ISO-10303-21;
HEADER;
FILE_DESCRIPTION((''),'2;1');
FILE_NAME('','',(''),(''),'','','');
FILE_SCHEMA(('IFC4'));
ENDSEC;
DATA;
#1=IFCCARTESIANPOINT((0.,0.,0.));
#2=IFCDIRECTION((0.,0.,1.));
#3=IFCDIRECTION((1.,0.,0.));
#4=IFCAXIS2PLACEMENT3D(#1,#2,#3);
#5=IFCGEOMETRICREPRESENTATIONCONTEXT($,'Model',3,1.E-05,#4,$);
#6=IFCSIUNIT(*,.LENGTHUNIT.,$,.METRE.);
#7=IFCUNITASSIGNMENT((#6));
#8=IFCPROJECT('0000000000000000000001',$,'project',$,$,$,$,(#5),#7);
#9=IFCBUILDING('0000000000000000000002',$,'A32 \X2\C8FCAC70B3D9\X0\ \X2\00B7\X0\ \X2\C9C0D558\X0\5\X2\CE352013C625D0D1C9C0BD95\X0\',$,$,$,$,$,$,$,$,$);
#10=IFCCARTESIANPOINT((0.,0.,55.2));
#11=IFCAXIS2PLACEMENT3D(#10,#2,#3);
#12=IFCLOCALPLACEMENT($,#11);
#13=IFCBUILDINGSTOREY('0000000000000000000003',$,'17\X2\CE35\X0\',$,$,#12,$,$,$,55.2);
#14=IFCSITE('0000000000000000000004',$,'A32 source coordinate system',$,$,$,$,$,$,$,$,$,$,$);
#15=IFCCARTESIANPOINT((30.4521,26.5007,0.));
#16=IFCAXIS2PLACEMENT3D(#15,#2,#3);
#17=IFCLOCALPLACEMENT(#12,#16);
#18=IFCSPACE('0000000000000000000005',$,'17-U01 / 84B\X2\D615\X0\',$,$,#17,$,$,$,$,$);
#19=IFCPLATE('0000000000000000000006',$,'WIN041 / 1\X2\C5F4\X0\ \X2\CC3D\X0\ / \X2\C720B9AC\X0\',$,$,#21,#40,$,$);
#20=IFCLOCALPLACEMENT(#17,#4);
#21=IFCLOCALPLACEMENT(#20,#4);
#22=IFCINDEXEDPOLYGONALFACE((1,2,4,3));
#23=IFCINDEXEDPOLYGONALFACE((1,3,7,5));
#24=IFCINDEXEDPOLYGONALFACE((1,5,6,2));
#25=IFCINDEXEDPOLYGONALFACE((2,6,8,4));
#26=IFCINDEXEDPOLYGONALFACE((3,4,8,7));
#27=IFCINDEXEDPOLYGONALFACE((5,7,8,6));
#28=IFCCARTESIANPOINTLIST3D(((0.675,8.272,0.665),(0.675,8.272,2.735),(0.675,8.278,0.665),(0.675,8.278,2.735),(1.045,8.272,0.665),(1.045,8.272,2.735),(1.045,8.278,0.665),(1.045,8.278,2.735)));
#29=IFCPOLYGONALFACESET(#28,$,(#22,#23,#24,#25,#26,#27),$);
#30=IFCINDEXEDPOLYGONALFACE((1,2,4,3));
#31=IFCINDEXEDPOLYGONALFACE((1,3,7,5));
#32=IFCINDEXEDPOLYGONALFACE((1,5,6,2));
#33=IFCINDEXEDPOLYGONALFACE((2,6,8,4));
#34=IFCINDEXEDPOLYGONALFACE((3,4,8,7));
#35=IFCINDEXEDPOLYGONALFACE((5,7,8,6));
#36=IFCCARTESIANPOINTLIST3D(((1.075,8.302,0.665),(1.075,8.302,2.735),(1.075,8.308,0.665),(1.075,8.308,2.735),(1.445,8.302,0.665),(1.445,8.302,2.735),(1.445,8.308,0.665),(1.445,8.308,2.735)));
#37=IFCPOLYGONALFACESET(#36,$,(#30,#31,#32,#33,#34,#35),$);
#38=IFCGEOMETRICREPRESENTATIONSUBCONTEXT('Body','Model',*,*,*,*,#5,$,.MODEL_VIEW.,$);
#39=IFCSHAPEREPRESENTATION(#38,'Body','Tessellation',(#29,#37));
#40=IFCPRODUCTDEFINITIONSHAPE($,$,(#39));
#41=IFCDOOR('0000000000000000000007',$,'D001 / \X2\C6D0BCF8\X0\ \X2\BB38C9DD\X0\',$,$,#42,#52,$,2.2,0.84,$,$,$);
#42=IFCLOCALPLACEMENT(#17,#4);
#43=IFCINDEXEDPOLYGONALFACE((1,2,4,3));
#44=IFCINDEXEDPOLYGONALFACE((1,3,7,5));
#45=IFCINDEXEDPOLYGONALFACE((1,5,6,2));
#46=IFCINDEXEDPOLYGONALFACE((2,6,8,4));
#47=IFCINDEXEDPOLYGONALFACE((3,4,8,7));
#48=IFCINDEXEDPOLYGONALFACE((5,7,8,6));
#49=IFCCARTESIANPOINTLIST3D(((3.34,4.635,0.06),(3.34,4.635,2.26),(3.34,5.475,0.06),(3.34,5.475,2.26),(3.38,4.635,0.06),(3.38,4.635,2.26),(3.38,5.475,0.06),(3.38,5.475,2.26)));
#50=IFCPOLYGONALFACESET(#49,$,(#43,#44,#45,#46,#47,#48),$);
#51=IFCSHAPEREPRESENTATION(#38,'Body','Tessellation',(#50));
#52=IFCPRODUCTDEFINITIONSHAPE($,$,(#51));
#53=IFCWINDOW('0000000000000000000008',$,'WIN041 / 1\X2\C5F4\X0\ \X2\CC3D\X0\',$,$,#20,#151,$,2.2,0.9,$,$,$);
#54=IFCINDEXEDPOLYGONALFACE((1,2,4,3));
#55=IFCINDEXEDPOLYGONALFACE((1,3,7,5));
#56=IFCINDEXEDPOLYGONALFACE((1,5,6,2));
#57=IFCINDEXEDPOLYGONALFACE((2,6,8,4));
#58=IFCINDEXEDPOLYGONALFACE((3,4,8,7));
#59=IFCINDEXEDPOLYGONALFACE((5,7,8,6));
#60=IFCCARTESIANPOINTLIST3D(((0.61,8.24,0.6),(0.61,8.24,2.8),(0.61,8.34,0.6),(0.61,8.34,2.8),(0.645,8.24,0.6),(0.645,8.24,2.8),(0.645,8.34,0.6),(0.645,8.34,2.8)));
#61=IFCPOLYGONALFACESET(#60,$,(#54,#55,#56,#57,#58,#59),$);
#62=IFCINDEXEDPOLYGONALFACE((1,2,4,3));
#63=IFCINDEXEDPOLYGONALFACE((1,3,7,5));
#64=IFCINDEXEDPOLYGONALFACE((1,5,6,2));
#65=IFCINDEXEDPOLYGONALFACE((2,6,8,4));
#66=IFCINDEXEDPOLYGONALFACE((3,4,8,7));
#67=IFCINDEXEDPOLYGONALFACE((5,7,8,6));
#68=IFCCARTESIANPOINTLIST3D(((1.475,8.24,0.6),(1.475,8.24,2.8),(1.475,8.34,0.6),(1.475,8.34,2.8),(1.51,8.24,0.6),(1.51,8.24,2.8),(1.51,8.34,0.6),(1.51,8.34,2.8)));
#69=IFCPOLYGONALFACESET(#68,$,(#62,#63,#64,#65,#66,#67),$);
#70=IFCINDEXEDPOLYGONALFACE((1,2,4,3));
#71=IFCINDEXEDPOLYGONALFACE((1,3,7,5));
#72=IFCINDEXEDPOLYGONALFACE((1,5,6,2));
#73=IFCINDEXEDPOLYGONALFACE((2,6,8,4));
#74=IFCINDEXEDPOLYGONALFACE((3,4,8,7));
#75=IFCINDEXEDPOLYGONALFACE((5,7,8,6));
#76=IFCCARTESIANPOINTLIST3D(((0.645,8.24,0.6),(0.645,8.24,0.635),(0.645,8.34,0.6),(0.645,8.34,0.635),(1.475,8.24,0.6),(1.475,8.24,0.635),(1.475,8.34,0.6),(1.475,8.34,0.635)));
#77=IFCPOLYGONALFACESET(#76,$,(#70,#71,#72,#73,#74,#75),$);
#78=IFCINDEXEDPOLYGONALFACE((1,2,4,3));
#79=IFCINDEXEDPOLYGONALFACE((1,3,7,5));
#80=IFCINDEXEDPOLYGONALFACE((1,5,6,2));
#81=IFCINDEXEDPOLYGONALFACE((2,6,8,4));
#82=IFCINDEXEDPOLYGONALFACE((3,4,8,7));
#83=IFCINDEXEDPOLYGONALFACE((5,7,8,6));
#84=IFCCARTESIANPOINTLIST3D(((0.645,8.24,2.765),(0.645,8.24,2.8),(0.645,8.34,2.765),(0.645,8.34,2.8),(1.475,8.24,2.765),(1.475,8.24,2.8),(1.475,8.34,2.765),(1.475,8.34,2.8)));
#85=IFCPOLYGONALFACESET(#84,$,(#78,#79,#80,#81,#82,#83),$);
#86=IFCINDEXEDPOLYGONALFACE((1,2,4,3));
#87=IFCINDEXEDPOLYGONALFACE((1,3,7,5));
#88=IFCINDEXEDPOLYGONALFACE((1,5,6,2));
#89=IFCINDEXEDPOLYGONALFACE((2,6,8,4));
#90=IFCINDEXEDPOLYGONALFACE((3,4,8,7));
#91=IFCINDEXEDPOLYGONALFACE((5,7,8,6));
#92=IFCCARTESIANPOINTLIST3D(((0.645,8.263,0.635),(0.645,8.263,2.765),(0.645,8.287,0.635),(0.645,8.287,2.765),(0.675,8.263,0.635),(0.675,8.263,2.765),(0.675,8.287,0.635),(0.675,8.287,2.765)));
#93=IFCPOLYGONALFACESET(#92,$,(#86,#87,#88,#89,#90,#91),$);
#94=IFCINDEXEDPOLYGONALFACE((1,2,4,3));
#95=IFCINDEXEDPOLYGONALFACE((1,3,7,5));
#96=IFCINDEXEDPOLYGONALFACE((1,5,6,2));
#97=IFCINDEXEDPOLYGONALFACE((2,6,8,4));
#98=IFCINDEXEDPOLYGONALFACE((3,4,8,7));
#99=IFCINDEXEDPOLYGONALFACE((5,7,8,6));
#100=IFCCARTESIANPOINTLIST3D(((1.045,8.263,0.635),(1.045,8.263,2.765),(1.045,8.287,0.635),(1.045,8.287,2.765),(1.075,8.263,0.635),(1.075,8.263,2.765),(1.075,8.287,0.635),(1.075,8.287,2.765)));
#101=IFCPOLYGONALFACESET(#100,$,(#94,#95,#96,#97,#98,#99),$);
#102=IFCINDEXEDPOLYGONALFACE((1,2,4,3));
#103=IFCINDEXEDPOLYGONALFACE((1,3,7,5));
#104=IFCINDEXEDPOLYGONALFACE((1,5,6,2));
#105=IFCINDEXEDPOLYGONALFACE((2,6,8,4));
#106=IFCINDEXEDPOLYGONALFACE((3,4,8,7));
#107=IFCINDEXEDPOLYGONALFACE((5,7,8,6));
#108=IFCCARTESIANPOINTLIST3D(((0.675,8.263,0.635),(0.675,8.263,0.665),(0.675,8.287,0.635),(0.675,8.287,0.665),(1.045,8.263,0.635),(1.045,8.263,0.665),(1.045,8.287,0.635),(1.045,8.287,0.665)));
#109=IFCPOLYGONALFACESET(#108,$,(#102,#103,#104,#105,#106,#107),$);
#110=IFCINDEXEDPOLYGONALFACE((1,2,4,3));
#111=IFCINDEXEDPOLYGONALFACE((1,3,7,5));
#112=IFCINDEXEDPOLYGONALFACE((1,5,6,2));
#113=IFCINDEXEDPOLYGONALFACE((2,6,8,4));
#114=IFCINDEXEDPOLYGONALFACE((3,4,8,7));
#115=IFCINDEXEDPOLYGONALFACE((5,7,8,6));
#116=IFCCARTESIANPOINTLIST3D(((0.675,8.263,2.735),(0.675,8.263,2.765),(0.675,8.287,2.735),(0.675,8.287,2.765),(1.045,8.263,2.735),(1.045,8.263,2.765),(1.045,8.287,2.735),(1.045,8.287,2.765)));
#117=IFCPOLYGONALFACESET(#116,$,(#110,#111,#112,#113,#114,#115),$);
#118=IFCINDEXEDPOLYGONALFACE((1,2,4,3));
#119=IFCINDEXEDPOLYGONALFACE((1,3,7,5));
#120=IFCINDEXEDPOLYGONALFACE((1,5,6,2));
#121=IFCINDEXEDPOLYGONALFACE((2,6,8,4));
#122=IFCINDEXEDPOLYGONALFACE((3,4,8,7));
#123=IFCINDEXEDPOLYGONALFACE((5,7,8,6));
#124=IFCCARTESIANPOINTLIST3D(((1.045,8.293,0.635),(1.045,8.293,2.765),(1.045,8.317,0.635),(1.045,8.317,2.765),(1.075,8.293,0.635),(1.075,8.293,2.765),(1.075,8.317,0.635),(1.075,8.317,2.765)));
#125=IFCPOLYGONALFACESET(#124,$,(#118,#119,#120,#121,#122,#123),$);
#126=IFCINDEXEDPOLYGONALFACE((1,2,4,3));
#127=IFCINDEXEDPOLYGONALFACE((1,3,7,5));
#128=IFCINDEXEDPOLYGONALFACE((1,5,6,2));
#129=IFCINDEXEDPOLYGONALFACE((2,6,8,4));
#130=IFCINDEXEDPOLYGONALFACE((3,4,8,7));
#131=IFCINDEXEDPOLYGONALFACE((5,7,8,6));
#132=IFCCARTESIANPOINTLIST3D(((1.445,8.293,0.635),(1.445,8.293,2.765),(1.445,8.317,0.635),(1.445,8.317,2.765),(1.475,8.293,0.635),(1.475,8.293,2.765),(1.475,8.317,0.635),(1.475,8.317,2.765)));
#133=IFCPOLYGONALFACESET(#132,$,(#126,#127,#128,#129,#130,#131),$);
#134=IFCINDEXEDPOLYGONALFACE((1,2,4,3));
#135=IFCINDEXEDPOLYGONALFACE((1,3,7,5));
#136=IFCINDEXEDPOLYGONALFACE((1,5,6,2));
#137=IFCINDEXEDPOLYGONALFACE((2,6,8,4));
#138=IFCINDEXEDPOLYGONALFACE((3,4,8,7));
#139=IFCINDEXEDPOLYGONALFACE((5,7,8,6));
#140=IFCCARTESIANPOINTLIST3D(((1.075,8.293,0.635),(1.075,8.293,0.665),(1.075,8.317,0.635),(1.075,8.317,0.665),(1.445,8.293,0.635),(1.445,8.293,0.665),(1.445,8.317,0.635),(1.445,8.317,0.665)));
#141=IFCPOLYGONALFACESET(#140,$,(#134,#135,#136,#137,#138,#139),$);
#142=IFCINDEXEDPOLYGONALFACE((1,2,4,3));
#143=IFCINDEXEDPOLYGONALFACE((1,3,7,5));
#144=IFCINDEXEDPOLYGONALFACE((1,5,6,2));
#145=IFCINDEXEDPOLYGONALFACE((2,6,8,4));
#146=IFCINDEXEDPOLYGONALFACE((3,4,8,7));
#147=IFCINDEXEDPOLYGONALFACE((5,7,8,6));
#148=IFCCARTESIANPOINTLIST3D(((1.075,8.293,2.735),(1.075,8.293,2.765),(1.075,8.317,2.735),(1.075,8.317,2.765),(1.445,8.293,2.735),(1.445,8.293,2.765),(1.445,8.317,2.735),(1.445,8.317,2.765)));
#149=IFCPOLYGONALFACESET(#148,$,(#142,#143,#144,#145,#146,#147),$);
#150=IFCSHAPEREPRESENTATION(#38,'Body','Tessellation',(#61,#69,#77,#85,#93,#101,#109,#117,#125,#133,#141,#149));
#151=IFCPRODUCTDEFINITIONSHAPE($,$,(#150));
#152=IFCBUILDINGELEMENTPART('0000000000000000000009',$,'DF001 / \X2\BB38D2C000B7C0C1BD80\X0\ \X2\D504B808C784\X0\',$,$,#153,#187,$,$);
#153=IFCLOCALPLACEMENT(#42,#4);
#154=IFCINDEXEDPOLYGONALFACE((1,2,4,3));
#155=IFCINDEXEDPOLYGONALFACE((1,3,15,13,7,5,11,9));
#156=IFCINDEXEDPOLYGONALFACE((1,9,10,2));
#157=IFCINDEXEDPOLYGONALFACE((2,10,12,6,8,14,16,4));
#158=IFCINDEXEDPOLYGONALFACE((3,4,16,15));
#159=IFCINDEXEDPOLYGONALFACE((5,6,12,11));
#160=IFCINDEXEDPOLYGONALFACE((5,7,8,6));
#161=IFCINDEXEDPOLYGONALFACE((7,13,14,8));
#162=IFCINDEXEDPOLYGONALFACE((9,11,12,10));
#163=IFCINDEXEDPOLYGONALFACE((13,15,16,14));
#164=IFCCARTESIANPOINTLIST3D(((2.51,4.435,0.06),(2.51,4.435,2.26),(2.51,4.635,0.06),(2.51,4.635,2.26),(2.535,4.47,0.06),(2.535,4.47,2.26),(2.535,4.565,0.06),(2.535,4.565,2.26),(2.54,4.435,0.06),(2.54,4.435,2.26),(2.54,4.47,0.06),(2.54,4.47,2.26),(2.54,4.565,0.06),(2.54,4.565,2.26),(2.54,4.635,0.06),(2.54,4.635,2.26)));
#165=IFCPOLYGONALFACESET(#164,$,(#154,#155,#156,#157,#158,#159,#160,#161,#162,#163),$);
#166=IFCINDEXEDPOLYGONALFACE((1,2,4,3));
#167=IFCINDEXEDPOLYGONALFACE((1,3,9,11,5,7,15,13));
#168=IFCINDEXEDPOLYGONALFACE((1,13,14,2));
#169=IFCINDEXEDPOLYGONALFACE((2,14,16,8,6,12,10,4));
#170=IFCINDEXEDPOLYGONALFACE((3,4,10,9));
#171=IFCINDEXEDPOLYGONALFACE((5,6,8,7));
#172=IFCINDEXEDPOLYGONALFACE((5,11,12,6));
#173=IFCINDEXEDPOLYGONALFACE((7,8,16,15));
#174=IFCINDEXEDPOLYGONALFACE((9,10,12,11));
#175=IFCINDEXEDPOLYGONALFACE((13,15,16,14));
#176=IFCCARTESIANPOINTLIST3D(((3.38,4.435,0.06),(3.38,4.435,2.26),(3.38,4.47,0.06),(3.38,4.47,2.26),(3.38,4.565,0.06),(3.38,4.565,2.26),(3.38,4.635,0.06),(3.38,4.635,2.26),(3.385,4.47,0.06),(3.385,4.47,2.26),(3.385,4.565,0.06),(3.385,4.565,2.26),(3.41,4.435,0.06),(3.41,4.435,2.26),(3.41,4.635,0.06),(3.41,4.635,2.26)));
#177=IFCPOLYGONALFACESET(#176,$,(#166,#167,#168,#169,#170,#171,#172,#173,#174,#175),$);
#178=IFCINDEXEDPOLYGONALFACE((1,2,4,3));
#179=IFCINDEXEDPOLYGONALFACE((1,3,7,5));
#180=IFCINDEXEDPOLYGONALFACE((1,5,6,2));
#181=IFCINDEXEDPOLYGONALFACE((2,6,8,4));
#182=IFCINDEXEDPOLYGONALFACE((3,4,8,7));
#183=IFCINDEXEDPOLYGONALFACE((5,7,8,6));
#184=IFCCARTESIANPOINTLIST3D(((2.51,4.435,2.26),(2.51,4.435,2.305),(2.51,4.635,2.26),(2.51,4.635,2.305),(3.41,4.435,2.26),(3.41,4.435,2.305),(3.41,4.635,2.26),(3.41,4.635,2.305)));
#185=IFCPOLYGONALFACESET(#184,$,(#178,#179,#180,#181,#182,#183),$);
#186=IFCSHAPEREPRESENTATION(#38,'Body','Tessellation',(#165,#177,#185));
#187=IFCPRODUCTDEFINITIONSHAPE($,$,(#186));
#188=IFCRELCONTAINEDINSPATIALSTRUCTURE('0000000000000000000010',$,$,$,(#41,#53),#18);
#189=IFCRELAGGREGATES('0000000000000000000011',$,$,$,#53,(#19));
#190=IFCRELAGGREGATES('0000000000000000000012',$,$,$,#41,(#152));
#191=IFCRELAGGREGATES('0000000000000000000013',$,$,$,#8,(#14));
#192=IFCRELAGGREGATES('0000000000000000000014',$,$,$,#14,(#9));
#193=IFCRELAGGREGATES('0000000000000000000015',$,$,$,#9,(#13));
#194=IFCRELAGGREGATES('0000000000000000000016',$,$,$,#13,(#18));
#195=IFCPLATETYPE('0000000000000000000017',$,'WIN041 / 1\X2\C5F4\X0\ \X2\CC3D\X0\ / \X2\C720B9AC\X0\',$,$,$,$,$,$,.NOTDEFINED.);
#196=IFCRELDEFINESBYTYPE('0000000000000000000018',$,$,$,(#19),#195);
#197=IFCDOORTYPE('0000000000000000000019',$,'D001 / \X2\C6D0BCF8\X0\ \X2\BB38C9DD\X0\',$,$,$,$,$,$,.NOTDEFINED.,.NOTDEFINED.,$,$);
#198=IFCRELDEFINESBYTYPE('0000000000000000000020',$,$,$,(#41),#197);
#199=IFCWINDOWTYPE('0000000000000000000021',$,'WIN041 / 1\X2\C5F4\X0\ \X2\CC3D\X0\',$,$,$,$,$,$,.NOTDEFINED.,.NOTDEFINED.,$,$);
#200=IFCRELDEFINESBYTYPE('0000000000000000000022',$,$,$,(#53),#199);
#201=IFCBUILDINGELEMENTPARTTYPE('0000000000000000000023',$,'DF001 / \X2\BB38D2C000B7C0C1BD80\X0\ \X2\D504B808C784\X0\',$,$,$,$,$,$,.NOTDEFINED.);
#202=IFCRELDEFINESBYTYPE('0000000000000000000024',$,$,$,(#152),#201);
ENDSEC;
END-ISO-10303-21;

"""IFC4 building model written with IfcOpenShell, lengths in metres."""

from ifc_helpers import new_model, si_unit, frame, origin, origin_with_axes, place, context, subcontext, project, spatial, polyline, outline, extrude, source, transform, mapped, type_object, type_shapes, element, aggregate, save


model = new_model("IFC4")

# Units and contexts
model_context = context("Model", 3, precision=1e-05, world=origin_with_axes())
body_context = subcontext(model_context, "Body", "Model", "MODEL_VIEW")
ifc_project = project(units=[si_unit("LENGTHUNIT", "METRE")], contexts=[model_context])

# Plate
storey_placement = place(None, frame((0.0, 0.0, 55.2), z_axis=(0.0, 0.0, 1.0), x_axis=(1.0, 0.0, 0.0)))
space_placement = place(storey_placement, frame((30.4521, 26.5007, 0.0), z_axis=(0.0, 0.0, 1.0), x_axis=(1.0, 0.0, 0.0)))
plate_type_1 = type_object("IfcPlateType", Name="WIN041 / 1열 창 / 유리", PredefinedType="NOTDEFINED")
shared_shape_1 = source(origin(), body_context, "Body", "SweptSolid", [
    extrude(outline(polyline([(0.675, 8.272), (0.675, 8.278), (1.045, 8.278), (1.045, 8.272), (0.675, 8.272)])), frame((0.0, 0.0, 0.665)), (0.0, 0.0, 1.0), 2.07),
    extrude(outline(polyline([(1.075, 8.302), (1.075, 8.308), (1.445, 8.308), (1.445, 8.302), (1.075, 8.302)])), frame((0.0, 0.0, 0.665)), (0.0, 0.0, 1.0), 2.07),
])
type_shapes(plate_type_1, [shared_shape_1])
window_1_placement = place(space_placement, origin_with_axes())
plate_1_placement = place(window_1_placement, origin_with_axes())
plate_1 = element("IfcPlate", 1, at=plate_1_placement, type_object=plate_type_1, Name="WIN041 / 1열 창 / 유리", context=body_context, shape_type="MappedRepresentation", body=[
    mapped(shared_shape_1, transform((0.0, 0.0, 0.0), scale=1.0)),
])

# Site, building, storey, space
site = spatial("IfcSite", under=ifc_project, Name="A32 source coordinate system")
building = spatial("IfcBuilding", under=site, Name="A32 주거동 · 지하5층–옥탑지붕")
storey = spatial("IfcBuildingStorey", under=building, at=storey_placement, Name="17층", Elevation=55.2)
space = spatial("IfcSpace", under=storey, at=space_placement, Name="17-U01 / 84B형")

# Door
door_type_1 = type_object("IfcDoorType", Name="D001 / 원본 문짝", OperationType="NOTDEFINED", PredefinedType="NOTDEFINED")
shared_shape_2 = source(origin(), body_context, "Body", "SweptSolid", [
    extrude(outline(polyline([(3.34, 5.475), (3.38, 5.475), (3.38, 4.635), (3.34, 4.635), (3.34, 5.475)])), frame((0.0, 0.0, 0.06)), (0.0, 0.0, 1.0), 2.2),
])
type_shapes(door_type_1, [shared_shape_2])
door_1_placement = place(space_placement, origin_with_axes())
door_1 = element("IfcDoor", 2, at=door_1_placement, inside=space, type_object=door_type_1, Name="D001 / 원본 문짝", OverallHeight=2.2, OverallWidth=0.84, context=body_context, shape_type="MappedRepresentation", body=[
    mapped(shared_shape_2, transform((0.0, 0.0, 0.0), scale=1.0)),
])

# Window
window_type_1 = type_object("IfcWindowType", Name="WIN041 / 1열 창", PartitioningType="NOTDEFINED", PredefinedType="NOTDEFINED")
shared_shape_3 = source(origin(), body_context, "Body", "SweptSolid", [
    extrude(outline(polyline([(0.61, 8.24), (0.61, 8.34), (0.645, 8.34), (0.645, 8.24), (0.61, 8.24)])), frame((0.0, 0.0, 0.6)), (0.0, 0.0, 1.0), 2.2),
    extrude(outline(polyline([(1.475, 8.24), (1.475, 8.34), (1.51, 8.34), (1.51, 8.24), (1.475, 8.24)])), frame((0.0, 0.0, 0.6)), (0.0, 0.0, 1.0), 2.2),
    extrude(outline(polyline([(0.645, 8.24), (0.645, 8.34), (1.475, 8.34), (1.475, 8.24), (0.645, 8.24)])), frame((0.0, 0.0, 0.6)), (0.0, 0.0, 1.0), 0.035),
    extrude(outline(polyline([(0.645, 8.24), (0.645, 8.34), (1.475, 8.34), (1.475, 8.24), (0.645, 8.24)])), frame((0.0, 0.0, 2.765)), (0.0, 0.0, 1.0), 0.035),
    extrude(outline(polyline([(0.645, 8.263), (0.645, 8.287), (0.675, 8.287), (0.675, 8.263), (0.645, 8.263)])), frame((0.0, 0.0, 0.635)), (0.0, 0.0, 1.0), 2.13),
    extrude(outline(polyline([(1.045, 8.263), (1.045, 8.287), (1.075, 8.287), (1.075, 8.263), (1.045, 8.263)])), frame((0.0, 0.0, 0.635)), (0.0, 0.0, 1.0), 2.13),
    extrude(outline(polyline([(0.675, 8.263), (0.675, 8.287), (1.045, 8.287), (1.045, 8.263), (0.675, 8.263)])), frame((0.0, 0.0, 0.635)), (0.0, 0.0, 1.0), 0.03),
    extrude(outline(polyline([(0.675, 8.263), (0.675, 8.287), (1.045, 8.287), (1.045, 8.263), (0.675, 8.263)])), frame((0.0, 0.0, 2.735)), (0.0, 0.0, 1.0), 0.03),
    extrude(outline(polyline([(1.045, 8.293), (1.045, 8.317), (1.075, 8.317), (1.075, 8.293), (1.045, 8.293)])), frame((0.0, 0.0, 0.635)), (0.0, 0.0, 1.0), 2.13),
    extrude(outline(polyline([(1.445, 8.293), (1.445, 8.317), (1.475, 8.317), (1.475, 8.293), (1.445, 8.293)])), frame((0.0, 0.0, 0.635)), (0.0, 0.0, 1.0), 2.13),
    extrude(outline(polyline([(1.075, 8.293), (1.075, 8.317), (1.445, 8.317), (1.445, 8.293), (1.075, 8.293)])), frame((0.0, 0.0, 0.635)), (0.0, 0.0, 1.0), 0.03),
    extrude(outline(polyline([(1.075, 8.293), (1.075, 8.317), (1.445, 8.317), (1.445, 8.293), (1.075, 8.293)])), frame((0.0, 0.0, 2.735)), (0.0, 0.0, 1.0), 0.03),
])
type_shapes(window_type_1, [shared_shape_3])
window_1 = element("IfcWindow", 3, at=window_1_placement, inside=space, type_object=window_type_1, Name="WIN041 / 1열 창", OverallHeight=2.2, OverallWidth=0.9, context=body_context, shape_type="MappedRepresentation", body=[
    mapped(shared_shape_3, transform((0.0, 0.0, 0.0), scale=1.0)),
])
aggregate(window_1, [plate_1])

# Building element part
building_element_part_type_1 = type_object("IfcBuildingElementPartType", Name="DF001 / 문틀·상부 프레임", PredefinedType="NOTDEFINED")
shared_shape_4 = source(origin(), body_context, "Body", "SweptSolid", [
    extrude(outline(polyline([(2.54, 4.635), (2.54, 4.565), (2.535, 4.565), (2.535, 4.47), (2.54, 4.47), (2.54, 4.435), (2.51, 4.435), (2.51, 4.635), (2.54, 4.635)])), frame((0.0, 0.0, 0.06)), (0.0, 0.0, 1.0), 2.2),
    extrude(outline(polyline([(3.41, 4.435), (3.38, 4.435), (3.38, 4.47), (3.385, 4.47), (3.385, 4.565), (3.38, 4.565), (3.38, 4.635), (3.41, 4.635), (3.41, 4.435)])), frame((0.0, 0.0, 0.06)), (0.0, 0.0, 1.0), 2.2),
    extrude(outline(polyline([(2.51, 4.435), (2.51, 4.635), (3.41, 4.635), (3.41, 4.435), (2.51, 4.435)])), frame((0.0, 0.0, 2.26)), (0.0, 0.0, 1.0), 0.045),
])
type_shapes(building_element_part_type_1, [shared_shape_4])
building_element_part_1_placement = place(door_1_placement, origin_with_axes())
building_element_part_1 = element("IfcBuildingElementPart", 4, at=building_element_part_1_placement, type_object=building_element_part_type_1, Name="DF001 / 문틀·상부 프레임", context=body_context, shape_type="MappedRepresentation", body=[
    mapped(shared_shape_4, transform((0.0, 0.0, 0.0), scale=1.0)),
])
aggregate(door_1, [building_element_part_1])

save(model, "model.ifc")
